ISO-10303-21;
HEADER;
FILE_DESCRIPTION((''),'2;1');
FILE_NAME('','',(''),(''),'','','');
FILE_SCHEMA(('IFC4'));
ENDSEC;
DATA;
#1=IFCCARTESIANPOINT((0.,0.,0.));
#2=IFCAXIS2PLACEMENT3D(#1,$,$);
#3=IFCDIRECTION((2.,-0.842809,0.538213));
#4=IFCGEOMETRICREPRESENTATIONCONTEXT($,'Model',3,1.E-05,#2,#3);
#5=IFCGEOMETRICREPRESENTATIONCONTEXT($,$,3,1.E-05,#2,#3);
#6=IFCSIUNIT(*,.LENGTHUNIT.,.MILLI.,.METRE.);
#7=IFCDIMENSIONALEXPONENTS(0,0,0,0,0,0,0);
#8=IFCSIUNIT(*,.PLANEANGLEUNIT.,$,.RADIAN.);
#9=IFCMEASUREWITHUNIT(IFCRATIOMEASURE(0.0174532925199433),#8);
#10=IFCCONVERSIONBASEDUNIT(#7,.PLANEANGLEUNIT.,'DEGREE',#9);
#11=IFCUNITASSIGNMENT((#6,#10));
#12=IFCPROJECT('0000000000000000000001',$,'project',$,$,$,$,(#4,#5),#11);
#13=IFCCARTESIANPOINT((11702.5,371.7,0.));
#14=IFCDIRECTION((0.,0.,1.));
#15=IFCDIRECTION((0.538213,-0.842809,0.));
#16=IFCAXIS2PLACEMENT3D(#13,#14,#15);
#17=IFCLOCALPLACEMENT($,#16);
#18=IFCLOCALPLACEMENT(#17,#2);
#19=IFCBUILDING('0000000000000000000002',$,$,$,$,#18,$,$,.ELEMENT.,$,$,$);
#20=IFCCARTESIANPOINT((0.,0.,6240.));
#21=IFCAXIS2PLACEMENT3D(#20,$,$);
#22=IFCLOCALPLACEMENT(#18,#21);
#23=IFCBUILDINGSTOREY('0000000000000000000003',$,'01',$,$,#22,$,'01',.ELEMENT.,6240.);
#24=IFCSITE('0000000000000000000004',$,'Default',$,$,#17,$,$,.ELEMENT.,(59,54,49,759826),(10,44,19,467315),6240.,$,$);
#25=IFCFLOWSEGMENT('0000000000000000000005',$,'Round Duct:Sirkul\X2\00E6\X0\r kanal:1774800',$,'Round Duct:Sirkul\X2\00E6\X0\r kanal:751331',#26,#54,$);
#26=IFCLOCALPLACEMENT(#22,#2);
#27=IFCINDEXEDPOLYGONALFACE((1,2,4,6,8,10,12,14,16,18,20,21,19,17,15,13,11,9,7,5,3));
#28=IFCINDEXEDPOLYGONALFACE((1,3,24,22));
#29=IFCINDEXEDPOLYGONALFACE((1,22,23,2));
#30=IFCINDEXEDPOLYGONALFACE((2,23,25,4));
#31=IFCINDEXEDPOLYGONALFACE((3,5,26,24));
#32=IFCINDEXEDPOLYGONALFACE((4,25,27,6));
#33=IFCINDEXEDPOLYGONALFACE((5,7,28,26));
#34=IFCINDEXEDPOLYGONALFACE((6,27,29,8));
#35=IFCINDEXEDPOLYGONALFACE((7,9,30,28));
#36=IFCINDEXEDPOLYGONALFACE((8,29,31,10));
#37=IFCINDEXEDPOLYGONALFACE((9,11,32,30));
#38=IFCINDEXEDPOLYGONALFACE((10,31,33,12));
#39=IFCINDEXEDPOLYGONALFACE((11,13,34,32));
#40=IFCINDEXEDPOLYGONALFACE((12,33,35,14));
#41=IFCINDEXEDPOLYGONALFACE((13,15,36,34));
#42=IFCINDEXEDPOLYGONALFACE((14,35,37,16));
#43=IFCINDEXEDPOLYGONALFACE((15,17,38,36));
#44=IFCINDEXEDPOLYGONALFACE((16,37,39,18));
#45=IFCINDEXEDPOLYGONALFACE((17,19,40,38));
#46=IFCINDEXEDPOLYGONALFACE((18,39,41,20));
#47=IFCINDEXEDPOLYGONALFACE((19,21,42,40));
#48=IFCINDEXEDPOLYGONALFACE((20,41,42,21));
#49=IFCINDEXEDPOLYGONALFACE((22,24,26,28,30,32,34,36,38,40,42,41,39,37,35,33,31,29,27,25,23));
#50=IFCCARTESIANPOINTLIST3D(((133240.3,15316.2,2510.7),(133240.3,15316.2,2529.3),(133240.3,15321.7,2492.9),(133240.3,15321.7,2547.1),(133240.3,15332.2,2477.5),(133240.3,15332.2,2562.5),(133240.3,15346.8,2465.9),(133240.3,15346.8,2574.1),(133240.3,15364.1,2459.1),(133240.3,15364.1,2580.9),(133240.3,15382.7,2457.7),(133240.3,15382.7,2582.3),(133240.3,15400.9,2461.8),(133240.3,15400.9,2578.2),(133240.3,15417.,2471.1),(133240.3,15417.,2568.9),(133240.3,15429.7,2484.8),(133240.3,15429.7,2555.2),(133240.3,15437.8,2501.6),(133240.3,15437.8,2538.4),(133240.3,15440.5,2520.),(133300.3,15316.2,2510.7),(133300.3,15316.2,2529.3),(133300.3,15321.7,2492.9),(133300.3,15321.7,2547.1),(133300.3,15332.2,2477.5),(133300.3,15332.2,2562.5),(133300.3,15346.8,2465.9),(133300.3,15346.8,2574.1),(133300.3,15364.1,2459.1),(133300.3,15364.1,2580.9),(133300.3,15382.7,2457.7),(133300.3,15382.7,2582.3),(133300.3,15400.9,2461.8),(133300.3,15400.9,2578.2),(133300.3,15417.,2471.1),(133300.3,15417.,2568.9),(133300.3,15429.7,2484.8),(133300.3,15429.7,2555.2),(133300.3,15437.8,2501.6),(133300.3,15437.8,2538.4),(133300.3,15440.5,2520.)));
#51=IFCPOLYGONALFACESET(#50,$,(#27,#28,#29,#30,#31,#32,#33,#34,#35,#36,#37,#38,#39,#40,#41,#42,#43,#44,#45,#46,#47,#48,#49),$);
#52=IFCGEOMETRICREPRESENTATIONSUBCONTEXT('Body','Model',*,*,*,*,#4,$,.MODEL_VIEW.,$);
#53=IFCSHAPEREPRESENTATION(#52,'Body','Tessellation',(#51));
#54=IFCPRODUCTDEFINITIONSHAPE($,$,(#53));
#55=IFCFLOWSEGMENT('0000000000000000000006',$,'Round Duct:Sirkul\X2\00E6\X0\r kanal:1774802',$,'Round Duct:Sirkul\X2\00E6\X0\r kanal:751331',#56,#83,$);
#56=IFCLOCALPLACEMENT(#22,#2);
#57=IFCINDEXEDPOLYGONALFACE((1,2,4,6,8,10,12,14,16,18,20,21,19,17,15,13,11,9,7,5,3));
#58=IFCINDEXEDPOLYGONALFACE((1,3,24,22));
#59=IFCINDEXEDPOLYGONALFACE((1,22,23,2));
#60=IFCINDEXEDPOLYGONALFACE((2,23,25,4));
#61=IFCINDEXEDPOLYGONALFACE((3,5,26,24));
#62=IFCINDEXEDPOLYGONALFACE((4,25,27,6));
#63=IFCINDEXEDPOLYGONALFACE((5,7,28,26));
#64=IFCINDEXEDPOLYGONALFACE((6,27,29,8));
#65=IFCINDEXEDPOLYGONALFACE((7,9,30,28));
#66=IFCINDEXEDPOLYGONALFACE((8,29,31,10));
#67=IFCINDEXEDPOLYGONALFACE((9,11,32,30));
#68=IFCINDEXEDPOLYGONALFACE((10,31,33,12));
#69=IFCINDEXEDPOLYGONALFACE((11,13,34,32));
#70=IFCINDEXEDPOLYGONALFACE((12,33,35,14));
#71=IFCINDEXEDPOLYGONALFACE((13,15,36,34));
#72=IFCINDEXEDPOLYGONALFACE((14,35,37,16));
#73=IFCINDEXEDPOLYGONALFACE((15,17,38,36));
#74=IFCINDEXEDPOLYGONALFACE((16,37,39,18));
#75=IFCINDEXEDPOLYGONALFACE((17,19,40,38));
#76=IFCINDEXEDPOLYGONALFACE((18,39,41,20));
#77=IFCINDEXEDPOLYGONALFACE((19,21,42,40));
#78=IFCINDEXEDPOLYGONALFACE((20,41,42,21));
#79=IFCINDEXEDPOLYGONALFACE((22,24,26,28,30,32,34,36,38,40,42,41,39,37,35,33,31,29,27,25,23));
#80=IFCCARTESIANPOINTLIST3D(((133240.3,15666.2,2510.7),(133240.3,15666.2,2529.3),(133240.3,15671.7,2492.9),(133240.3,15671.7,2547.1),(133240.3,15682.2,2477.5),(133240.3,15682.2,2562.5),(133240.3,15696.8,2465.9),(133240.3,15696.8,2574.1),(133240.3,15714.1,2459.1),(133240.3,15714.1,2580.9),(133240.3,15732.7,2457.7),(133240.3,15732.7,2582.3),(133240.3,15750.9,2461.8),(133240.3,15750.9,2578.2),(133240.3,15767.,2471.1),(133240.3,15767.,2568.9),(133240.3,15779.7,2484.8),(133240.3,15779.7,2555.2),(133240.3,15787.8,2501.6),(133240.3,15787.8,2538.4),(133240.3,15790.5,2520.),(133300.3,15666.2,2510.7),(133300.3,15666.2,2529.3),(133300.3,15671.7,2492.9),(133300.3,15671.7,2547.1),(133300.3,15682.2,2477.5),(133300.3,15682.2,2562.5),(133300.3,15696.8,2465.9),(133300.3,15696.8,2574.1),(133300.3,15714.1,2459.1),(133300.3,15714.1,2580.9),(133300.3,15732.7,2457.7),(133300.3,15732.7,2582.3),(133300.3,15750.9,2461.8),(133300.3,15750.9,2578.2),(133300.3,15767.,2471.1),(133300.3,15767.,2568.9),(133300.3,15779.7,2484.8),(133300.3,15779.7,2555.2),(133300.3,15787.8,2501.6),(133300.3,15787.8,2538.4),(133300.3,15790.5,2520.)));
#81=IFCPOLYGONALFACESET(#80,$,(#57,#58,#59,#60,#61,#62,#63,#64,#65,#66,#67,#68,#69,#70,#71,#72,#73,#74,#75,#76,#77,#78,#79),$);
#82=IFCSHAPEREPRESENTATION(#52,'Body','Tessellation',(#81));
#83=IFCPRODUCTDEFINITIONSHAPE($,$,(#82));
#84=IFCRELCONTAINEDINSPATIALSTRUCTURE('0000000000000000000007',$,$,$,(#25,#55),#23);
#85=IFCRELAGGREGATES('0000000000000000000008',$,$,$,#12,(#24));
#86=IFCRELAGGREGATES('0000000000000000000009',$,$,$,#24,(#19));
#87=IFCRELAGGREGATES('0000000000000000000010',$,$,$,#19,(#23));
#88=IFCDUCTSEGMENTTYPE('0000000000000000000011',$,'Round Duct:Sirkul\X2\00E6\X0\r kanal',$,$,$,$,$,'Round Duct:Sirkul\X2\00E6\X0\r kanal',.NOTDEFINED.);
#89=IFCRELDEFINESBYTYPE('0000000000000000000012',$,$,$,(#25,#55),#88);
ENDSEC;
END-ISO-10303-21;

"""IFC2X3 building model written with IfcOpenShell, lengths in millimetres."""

from ifc_helpers import new_model, entity, si_unit, converted_unit, direction, frame, frame_2d, origin, origin_2d_with_axis, place, context, subcontext, project, spatial, circle, extrude, type_object, element, save


model = new_model("IFC2X3")

# Units and contexts
model_context = context("Model", 3, precision=1e-05, world=origin(), true_north=direction((2.0, -0.842809, 0.538213)))
context_of_model = context(None, 3, precision=1e-05, world=origin(), true_north=direction((2.0, -0.842809, 0.538213)))
body_context = subcontext(model_context, "Body", "Model", "MODEL_VIEW")
ifc_project = project(units=[si_unit("LENGTHUNIT", "METRE", prefix="MILLI"), converted_unit("PLANEANGLEUNIT", "DEGREE", entity("IfcRatioMeasure", 0.0174532925199433), si_unit("PLANEANGLEUNIT", "RADIAN"), dimensions=[0, 0, 0, 0, 0, 0, 0])], contexts=[model_context, context_of_model])

# Site, building, storey
site_placement = place(None, frame((11702.5, 371.7, 0.0), z_axis=(0.0, 0.0, 1.0), x_axis=(0.538213, -0.842809, 0.0)))
site = spatial("IfcSite", under=ifc_project, at=site_placement, Name="Default", CompositionType="ELEMENT", RefLatitude=(59, 54, 49, 759826), RefLongitude=(10, 44, 19, 467315), RefElevation=6240.0)
building_placement = place(site_placement, origin())
building = spatial("IfcBuilding", under=site, at=building_placement, CompositionType="ELEMENT")
storey_placement = place(building_placement, frame((0.0, 0.0, 6240.0)))
storey = spatial("IfcBuildingStorey", under=building, at=storey_placement, Name="01", LongName="01", CompositionType="ELEMENT", Elevation=6240.0)

# Flow segments
duct_segment_type = type_object("IfcDuctSegmentType", Name="Round Duct:Sirkulær kanal", ElementType="Round Duct:Sirkulær kanal", PredefinedType="NOTDEFINED")
flow_segment_1_placement = place(storey_placement, origin())
element("IfcFlowSegment", 1, at=flow_segment_1_placement, inside=storey, type_object=duct_segment_type, Name="Round Duct:Sirkulær kanal:1774800", ObjectType="Round Duct:Sirkulær kanal:751331", context=body_context, shape_type="SweptSolid", body=[
    extrude(circle(Radius=62.5, at=frame_2d((0.0, 0.0), x_axis=(1.0, 0.0))), frame((133240.3, 15378.0, 2520.0), z_axis=(1.0, 0.0, 0.0), x_axis=(0.0, 1.0, 0.0)), (0.0, 0.0, 1.0), 60.0),
])
flow_segment_2_placement = place(storey_placement, origin())
element("IfcFlowSegment", 2, at=flow_segment_2_placement, inside=storey, type_object=duct_segment_type, Name="Round Duct:Sirkulær kanal:1774802", ObjectType="Round Duct:Sirkulær kanal:751331", context=body_context, shape_type="SweptSolid", body=[
    extrude(circle(Radius=62.5, at=origin_2d_with_axis()), frame((133240.3, 15728.0, 2520.0), z_axis=(1.0, 0.0, 0.0), x_axis=(0.0, 1.0, 0.0)), (0.0, 0.0, 1.0), 60.0),
])

save(model, "model.ifc")
